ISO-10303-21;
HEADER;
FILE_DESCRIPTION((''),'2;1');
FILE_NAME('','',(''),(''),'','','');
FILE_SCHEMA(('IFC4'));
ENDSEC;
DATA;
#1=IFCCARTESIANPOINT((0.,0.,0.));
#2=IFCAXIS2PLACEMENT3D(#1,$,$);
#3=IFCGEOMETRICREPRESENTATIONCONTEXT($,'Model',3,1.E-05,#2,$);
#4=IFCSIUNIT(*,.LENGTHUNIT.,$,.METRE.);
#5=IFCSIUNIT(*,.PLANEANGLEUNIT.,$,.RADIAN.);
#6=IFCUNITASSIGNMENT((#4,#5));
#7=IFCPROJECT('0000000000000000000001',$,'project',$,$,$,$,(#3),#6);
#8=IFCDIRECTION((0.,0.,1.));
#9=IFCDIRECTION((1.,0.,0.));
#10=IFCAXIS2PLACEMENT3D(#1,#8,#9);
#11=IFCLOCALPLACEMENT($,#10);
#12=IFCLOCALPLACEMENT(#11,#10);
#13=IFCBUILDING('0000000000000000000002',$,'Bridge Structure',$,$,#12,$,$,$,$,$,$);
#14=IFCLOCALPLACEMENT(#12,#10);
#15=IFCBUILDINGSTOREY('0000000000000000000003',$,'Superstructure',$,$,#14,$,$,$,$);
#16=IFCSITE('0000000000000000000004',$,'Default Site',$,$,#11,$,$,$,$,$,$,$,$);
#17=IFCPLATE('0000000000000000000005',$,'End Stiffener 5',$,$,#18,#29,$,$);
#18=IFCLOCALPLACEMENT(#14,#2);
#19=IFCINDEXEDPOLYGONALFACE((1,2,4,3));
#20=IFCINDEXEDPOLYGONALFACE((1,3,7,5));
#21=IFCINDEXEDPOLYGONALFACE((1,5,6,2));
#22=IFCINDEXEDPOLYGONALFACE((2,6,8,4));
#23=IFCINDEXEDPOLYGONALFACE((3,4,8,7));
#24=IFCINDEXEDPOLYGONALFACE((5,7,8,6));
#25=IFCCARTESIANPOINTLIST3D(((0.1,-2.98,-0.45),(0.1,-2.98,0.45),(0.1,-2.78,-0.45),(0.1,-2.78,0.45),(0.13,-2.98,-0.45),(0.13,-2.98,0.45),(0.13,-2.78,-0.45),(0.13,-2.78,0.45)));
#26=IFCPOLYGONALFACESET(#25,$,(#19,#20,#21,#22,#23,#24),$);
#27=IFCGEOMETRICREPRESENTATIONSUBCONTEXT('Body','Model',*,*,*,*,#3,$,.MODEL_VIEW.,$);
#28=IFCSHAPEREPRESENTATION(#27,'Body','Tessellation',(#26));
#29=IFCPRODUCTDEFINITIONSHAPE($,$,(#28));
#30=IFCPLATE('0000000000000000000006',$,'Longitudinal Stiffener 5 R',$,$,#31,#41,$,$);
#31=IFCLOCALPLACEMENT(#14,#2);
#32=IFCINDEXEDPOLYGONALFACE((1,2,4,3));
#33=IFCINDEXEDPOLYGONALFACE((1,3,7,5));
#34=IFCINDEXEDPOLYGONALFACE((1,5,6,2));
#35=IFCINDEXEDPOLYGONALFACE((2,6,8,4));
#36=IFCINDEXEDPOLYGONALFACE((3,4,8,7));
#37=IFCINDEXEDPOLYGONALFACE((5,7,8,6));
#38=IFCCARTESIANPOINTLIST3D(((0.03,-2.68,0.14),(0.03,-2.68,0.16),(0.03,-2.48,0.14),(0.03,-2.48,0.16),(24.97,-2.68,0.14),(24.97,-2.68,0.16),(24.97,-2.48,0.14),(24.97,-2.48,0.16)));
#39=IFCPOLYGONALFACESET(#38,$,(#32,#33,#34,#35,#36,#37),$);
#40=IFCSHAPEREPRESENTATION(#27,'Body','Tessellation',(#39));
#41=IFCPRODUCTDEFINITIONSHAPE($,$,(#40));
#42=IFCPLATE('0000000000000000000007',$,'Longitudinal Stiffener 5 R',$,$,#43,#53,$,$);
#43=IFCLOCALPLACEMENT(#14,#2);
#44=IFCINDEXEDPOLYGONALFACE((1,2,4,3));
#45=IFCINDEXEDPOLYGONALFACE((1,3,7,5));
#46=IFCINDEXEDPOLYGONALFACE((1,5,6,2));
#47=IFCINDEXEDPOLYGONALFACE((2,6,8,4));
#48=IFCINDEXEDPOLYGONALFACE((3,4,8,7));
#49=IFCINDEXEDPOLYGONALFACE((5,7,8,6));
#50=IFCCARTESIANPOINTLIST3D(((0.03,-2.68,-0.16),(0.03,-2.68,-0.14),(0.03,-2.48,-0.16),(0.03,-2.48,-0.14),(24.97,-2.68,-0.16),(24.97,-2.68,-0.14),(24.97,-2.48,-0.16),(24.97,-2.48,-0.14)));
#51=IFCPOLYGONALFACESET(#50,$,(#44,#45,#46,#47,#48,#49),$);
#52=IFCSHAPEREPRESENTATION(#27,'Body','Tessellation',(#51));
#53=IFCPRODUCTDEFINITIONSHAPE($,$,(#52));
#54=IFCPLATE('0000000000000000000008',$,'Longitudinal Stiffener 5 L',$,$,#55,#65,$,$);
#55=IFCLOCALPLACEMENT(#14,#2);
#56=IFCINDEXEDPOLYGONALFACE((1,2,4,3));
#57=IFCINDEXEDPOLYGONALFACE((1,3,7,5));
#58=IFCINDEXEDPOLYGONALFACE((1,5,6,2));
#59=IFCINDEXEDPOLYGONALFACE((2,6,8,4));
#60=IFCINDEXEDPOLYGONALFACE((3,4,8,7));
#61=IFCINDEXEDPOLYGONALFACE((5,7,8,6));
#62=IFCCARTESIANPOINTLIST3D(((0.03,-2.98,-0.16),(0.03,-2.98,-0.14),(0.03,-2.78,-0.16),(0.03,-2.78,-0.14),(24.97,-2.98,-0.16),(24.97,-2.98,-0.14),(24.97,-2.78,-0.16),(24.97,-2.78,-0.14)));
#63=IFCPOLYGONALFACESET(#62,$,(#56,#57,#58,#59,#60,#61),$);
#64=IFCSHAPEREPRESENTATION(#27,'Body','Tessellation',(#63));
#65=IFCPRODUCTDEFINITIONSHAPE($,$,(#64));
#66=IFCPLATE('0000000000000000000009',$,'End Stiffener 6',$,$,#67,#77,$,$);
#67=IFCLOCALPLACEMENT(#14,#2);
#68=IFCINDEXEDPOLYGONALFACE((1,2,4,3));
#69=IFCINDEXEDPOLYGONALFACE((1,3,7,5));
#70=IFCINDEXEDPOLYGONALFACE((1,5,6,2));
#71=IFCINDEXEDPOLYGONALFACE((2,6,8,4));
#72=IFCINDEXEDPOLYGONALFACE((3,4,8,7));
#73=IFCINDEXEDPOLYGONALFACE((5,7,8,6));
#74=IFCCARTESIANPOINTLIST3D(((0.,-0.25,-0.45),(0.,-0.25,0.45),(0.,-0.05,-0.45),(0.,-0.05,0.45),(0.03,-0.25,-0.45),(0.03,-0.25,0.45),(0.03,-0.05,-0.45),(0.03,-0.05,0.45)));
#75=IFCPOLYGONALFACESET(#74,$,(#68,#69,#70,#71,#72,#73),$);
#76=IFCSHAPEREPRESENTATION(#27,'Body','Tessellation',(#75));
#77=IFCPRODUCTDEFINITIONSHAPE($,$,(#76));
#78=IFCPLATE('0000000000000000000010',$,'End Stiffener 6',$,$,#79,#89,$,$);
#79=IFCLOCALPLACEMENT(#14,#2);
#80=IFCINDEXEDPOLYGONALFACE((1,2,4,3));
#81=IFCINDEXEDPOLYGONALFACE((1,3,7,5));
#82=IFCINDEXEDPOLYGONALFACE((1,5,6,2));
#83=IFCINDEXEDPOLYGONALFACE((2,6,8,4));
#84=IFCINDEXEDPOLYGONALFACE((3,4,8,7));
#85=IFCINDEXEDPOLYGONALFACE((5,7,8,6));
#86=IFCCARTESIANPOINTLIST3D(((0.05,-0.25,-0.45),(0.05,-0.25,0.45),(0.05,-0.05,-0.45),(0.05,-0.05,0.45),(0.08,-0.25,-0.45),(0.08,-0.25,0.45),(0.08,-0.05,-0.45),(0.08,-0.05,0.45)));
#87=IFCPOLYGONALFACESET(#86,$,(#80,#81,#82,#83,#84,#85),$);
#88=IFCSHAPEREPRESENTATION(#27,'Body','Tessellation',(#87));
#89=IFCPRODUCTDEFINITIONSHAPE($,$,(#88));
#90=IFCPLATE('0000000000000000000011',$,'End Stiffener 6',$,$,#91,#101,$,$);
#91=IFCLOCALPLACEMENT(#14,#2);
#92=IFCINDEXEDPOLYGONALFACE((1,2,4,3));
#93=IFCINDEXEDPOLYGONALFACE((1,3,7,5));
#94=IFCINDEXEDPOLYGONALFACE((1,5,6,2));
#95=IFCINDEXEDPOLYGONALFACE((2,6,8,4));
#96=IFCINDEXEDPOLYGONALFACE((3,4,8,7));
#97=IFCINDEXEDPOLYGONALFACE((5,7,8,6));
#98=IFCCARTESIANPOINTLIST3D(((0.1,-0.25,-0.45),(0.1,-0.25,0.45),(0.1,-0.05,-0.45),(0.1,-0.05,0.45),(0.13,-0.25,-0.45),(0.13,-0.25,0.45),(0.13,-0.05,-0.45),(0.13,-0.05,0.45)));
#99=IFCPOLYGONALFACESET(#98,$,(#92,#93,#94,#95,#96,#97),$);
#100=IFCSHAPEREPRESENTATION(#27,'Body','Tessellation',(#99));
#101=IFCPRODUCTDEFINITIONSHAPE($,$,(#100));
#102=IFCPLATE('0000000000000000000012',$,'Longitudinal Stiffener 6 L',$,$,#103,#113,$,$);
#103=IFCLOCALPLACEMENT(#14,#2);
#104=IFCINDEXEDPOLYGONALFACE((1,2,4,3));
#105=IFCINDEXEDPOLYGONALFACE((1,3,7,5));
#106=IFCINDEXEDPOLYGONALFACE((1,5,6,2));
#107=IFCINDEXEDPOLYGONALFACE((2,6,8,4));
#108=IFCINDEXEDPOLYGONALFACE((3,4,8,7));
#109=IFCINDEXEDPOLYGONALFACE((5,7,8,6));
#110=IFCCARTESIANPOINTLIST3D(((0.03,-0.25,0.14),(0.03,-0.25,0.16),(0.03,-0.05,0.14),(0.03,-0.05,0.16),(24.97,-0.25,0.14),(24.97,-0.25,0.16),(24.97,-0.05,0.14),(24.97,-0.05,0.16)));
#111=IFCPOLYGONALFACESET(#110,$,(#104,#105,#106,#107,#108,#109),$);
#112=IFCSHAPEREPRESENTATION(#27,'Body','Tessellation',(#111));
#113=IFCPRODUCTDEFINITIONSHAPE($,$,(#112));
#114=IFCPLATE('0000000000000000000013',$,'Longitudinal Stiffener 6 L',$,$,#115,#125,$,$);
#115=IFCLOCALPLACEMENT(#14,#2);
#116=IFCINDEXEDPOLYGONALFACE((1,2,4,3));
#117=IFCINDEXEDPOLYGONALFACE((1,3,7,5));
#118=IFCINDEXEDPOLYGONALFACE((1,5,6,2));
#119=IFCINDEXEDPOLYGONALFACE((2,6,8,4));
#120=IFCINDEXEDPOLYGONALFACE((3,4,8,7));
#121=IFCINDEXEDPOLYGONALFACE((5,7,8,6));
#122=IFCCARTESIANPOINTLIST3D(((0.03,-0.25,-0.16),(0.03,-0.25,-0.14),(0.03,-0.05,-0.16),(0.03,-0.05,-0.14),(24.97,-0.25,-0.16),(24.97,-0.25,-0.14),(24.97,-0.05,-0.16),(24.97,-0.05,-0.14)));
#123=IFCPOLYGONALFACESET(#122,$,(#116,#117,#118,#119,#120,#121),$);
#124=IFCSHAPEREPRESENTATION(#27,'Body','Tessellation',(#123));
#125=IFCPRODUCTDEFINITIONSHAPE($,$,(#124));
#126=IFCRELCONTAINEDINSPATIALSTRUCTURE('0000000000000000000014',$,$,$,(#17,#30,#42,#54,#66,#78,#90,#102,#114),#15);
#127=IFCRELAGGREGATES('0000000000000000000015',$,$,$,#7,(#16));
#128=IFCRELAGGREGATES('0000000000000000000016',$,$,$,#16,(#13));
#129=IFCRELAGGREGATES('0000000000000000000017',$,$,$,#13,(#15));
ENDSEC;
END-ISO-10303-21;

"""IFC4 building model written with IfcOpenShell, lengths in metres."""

from ifc_helpers import new_model, si_unit, frame, origin, origin_with_axes, origin_2d_with_axis, place, context, subcontext, project, spatial, rectangle, extrude, element, save


model = new_model("IFC4")

# Units and contexts
model_context = context("Model", 3, precision=1e-05, world=origin())
body_context = subcontext(model_context, "Body", "Model", "MODEL_VIEW")
ifc_project = project(units=[si_unit("LENGTHUNIT", "METRE"), si_unit("PLANEANGLEUNIT", "RADIAN")], contexts=[model_context])

# Site, building, storey
site_placement = place(None, origin_with_axes())
site = spatial("IfcSite", under=ifc_project, at=site_placement, Name="Default Site")
building_placement = place(site_placement, origin_with_axes())
building = spatial("IfcBuilding", under=site, at=building_placement, Name="Bridge Structure")
storey_placement = place(building_placement, origin_with_axes())
storey = spatial("IfcBuildingStorey", under=building, at=storey_placement, Name="Superstructure")

# Plates
for number, where, z_axis, x_axis, name in (
    (1, (0.115, -2.88, -0.45), (0.0, 0.0, 1.0), (1.0, 0.0, 0.0), "End Stiffener 5"),
):
    element("IfcPlate", number, at=place(storey_placement, frame(where, z_axis=z_axis, x_axis=x_axis)), inside=storey, Name=name, context=body_context, shape_type="SweptSolid", body=[
        extrude(rectangle(XDim=0.03, YDim=0.2, at=origin_2d_with_axis()), origin_with_axes(), (0.0, 0.0, 1.0), 0.9),
    ])
for number, where, z_axis, x_axis, name in (
    (2, (0.03, -2.58, 0.15), (1.0, 0.0, 0.0), (0.0, 1.0, 0.0), "Longitudinal Stiffener 5 R"),
    (3, (0.03, -2.58, -0.15), (1.0, 0.0, 0.0), (0.0, 1.0, 0.0), "Longitudinal Stiffener 5 R"),
    (4, (0.03, -2.88, -0.15), (1.0, 0.0, 0.0), (0.0, 1.0, 0.0), "Longitudinal Stiffener 5 L"),
):
    element("IfcPlate", number, at=place(storey_placement, frame(where, z_axis=z_axis, x_axis=x_axis)), inside=storey, Name=name, context=body_context, shape_type="SweptSolid", body=[
        extrude(rectangle(XDim=0.2, YDim=0.02, at=origin_2d_with_axis()), origin_with_axes(), (0.0, 0.0, 1.0), 24.94),
    ])
for number, where, z_axis, x_axis, name in (
    (5, (0.015, -0.15, -0.45), (0.0, 0.0, 1.0), (1.0, 0.0, 0.0), "End Stiffener 6"),
    (6, (0.065, -0.15, -0.45), (0.0, 0.0, 1.0), (1.0, 0.0, 0.0), "End Stiffener 6"),
    (7, (0.115, -0.15, -0.45), (0.0, 0.0, 1.0), (1.0, 0.0, 0.0), "End Stiffener 6"),
):
    element("IfcPlate", number, at=place(storey_placement, frame(where, z_axis=z_axis, x_axis=x_axis)), inside=storey, Name=name, context=body_context, shape_type="SweptSolid", body=[
        extrude(rectangle(XDim=0.03, YDim=0.2, at=origin_2d_with_axis()), origin_with_axes(), (0.0, 0.0, 1.0), 0.9),
    ])
for number, where, z_axis, x_axis, name in (
    (8, (0.03, -0.15, 0.15), (1.0, 0.0, 0.0), (0.0, 1.0, 0.0), "Longitudinal Stiffener 6 L"),
    (9, (0.03, -0.15, -0.15), (1.0, 0.0, 0.0), (0.0, 1.0, 0.0), "Longitudinal Stiffener 6 L"),
):
    element("IfcPlate", number, at=place(storey_placement, frame(where, z_axis=z_axis, x_axis=x_axis)), inside=storey, Name=name, context=body_context, shape_type="SweptSolid", body=[
        extrude(rectangle(XDim=0.2, YDim=0.02, at=origin_2d_with_axis()), origin_with_axes(), (0.0, 0.0, 1.0), 24.94),
    ])

save(model, "model.ifc")
